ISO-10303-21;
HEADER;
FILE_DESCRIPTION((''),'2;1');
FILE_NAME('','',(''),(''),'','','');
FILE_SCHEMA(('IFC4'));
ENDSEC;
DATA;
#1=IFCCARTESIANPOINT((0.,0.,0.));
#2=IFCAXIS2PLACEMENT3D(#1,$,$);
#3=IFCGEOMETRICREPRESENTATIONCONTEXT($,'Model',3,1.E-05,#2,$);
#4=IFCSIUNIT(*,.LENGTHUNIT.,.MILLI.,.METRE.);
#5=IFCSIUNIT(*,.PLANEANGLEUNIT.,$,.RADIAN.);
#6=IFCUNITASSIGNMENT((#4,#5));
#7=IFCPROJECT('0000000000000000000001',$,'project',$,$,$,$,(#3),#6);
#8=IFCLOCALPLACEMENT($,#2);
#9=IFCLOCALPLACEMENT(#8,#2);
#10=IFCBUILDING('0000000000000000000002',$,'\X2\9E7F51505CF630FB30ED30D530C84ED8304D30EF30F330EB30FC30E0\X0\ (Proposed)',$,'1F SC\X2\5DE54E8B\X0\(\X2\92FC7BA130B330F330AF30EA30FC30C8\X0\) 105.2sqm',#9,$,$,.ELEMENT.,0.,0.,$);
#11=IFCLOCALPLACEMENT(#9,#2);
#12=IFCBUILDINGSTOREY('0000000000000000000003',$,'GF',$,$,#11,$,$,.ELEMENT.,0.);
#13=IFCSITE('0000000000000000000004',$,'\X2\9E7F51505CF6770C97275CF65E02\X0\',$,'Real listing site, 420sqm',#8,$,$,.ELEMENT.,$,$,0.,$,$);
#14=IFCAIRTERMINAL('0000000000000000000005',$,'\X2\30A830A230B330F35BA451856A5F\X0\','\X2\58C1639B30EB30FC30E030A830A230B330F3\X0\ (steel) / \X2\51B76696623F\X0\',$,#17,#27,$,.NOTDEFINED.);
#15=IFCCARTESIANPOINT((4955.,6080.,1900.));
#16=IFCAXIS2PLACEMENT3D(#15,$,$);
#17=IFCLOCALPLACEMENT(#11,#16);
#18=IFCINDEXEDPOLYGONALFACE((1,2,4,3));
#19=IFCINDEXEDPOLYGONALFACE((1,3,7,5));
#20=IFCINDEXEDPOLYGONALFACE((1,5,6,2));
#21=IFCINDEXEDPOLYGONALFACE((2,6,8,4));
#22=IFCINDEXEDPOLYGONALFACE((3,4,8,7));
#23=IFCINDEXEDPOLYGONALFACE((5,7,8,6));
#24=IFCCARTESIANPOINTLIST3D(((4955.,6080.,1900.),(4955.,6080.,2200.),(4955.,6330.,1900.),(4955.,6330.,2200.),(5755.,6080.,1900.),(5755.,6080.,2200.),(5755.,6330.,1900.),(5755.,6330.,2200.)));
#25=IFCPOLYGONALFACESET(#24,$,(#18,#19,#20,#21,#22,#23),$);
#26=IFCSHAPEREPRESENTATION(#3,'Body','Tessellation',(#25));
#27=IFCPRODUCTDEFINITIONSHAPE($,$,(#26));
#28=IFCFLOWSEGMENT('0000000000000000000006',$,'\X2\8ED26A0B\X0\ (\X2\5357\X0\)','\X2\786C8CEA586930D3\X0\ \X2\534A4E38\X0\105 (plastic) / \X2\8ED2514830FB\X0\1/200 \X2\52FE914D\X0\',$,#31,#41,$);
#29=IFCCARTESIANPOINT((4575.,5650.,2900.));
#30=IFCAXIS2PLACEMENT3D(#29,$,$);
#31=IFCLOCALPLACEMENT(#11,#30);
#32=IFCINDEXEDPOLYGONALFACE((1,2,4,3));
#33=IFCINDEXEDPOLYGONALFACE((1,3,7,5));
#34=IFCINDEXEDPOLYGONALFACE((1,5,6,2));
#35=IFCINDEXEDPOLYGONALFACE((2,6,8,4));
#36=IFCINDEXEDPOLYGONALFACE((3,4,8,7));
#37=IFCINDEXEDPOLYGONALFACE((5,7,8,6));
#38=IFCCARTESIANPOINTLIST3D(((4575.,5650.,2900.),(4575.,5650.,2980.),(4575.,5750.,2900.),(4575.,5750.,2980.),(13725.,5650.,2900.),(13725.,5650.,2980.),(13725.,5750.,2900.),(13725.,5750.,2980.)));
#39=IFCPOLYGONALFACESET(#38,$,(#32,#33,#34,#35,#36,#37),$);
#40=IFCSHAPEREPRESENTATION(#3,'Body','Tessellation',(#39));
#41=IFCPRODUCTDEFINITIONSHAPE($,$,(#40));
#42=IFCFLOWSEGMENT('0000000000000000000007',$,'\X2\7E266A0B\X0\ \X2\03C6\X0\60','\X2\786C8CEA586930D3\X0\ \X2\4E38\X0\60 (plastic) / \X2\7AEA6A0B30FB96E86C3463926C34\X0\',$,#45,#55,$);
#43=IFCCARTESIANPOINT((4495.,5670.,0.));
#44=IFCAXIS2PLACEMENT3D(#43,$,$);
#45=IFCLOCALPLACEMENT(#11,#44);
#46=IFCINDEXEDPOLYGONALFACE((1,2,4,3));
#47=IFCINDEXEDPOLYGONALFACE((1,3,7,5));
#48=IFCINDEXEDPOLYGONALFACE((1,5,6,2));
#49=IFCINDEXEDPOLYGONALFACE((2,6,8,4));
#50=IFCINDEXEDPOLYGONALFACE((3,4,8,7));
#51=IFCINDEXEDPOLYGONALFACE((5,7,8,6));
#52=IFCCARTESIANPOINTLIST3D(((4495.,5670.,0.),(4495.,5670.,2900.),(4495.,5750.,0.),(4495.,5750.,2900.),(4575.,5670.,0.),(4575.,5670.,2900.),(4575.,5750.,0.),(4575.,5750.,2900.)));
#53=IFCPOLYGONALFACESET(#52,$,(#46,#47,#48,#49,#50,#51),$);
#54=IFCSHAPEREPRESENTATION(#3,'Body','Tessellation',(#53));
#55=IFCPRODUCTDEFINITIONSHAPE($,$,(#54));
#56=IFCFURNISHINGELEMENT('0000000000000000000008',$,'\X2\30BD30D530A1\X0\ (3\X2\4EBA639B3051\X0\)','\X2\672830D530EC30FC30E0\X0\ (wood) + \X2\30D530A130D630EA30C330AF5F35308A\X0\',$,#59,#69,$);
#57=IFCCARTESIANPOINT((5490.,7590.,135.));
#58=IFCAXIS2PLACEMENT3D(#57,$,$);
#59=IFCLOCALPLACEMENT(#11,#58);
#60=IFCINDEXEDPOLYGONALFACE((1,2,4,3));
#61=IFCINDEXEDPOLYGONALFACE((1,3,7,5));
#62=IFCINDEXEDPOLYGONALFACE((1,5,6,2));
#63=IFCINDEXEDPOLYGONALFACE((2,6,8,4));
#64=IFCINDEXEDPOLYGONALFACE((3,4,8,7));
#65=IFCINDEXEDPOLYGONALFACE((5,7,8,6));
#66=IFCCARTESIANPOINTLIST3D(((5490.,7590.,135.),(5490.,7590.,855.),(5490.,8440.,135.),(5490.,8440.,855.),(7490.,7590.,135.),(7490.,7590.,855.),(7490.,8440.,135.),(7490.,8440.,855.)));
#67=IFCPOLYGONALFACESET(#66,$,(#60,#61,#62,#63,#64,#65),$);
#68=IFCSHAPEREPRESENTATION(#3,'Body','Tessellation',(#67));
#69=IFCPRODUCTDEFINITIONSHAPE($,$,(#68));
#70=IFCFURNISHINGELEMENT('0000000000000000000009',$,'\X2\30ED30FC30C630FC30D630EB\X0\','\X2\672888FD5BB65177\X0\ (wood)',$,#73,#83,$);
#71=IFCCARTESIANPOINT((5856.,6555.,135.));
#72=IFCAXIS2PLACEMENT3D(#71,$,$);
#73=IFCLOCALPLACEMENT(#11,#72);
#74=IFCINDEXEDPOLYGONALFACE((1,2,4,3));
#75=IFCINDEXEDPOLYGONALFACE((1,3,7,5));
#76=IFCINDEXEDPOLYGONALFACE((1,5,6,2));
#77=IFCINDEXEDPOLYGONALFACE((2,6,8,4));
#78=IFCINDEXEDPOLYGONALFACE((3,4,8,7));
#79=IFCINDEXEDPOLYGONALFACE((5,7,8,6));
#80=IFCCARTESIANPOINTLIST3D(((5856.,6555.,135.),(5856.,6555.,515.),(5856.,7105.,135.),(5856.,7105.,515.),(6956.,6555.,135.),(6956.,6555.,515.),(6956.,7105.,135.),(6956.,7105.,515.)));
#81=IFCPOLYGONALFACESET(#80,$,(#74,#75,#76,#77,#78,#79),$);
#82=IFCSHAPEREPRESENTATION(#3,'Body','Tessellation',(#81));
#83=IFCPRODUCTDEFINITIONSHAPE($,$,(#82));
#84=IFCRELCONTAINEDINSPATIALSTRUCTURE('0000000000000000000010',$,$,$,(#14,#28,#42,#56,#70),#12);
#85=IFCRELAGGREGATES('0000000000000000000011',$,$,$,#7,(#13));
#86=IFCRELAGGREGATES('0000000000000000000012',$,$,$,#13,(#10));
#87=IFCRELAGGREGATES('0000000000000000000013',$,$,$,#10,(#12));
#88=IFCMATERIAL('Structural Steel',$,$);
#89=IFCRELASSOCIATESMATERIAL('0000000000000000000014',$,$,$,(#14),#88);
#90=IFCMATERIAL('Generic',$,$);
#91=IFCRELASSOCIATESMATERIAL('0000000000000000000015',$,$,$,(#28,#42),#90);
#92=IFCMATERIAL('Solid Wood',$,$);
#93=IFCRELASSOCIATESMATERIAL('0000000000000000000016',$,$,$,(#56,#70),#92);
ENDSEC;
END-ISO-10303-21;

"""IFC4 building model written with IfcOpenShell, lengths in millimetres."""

from ifc_helpers import new_model, si_unit, frame, frame_2d, origin, place, context, project, spatial, rectangle, extrude, material, element, save


model = new_model("IFC4")

# Units and contexts
model_context = context("Model", 3, precision=1e-05, world=origin())
ifc_project = project(units=[si_unit("LENGTHUNIT", "METRE", prefix="MILLI"), si_unit("PLANEANGLEUNIT", "RADIAN")], contexts=[model_context])

# Site, building, storey
site_placement = place(None, origin())
site = spatial("IfcSite", under=ifc_project, at=site_placement, Name="鹿児島県霧島市", ObjectType="Real listing site, 420sqm", CompositionType="ELEMENT", RefElevation=0.0)
building_placement = place(site_placement, origin())
building = spatial("IfcBuilding", under=site, at=building_placement, Name="鹿児島・ロフト付きワンルーム (Proposed)", ObjectType="1F SC工事(鋼管コンクリート) 105.2sqm", CompositionType="ELEMENT", ElevationOfRefHeight=0.0, ElevationOfTerrain=0.0)
storey_placement = place(building_placement, origin())
storey = spatial("IfcBuildingStorey", under=building, at=storey_placement, Name="GF", CompositionType="ELEMENT", Elevation=0.0)

# Shared definitions
ifc_material_1 = material(Name="Solid Wood")

# Shared definitions
ifc_material_2 = material(Name="Structural Steel")

# Shared definitions
ifc_material_3 = material(Name="Generic")

# Air terminal
air_terminal_placement = place(storey_placement, frame((4955.0, 6080.0, 1900.0)))
element("IfcAirTerminal", 1, at=air_terminal_placement, inside=storey, material=ifc_material_2, Name="エアコン室内機", Description="壁掛ルームエアコン (steel) / 冷暖房", PredefinedType="NOTDEFINED", context=model_context, shape_type="SweptSolid", body=[
    extrude(rectangle(XDim=800.0, YDim=250.0, at=frame_2d((400.0, 125.0))), frame((4955.0, 6080.0, 1900.0)), (0.0, 0.0, 1.0), 300.0),
])

# Flow segments
flow_segment_1_placement = place(storey_placement, frame((4575.0, 5650.0, 2900.0)))
element("IfcFlowSegment", 2, at=flow_segment_1_placement, inside=storey, material=ifc_material_3, Name="軒樋 (南)", Description="硬質塩ビ 半丸105 (plastic) / 軒先・1/200 勾配", context=model_context, shape_type="SweptSolid", body=[
    extrude(rectangle(XDim=9150.0, YDim=100.0, at=frame_2d((4575.0, 50.0))), frame((4575.0, 5650.0, 2900.0)), (0.0, 0.0, 1.0), 80.0),
])
flow_segment_2_placement = place(storey_placement, frame((4495.0, 5670.0, 0.0)))
element("IfcFlowSegment", 3, at=flow_segment_2_placement, inside=storey, material=ifc_material_3, Name="縦樋 φ60", Description="硬質塩ビ 丸60 (plastic) / 竪樋・雨水排水", context=model_context, shape_type="SweptSolid", body=[
    extrude(rectangle(XDim=80.0, YDim=80.0, at=frame_2d((40.0, 40.0))), frame((4495.0, 5670.0, 0.0)), (0.0, 0.0, 1.0), 2900.0),
])

# Furnishing elements
furnishing_1_placement = place(storey_placement, frame((5490.0, 7590.0, 135.0)))
element("IfcFurnishingElement", 4, at=furnishing_1_placement, inside=storey, material=ifc_material_1, Name="ソファ (3人掛け)", Description="木フレーム (wood) + ファブリック張り", context=model_context, shape_type="SweptSolid", body=[
    extrude(rectangle(XDim=2000.0, YDim=850.0, at=frame_2d((1000.0, 425.0))), frame((5490.0, 7590.0, 135.0)), (0.0, 0.0, 1.0), 720.0),
])
furnishing_2_placement = place(storey_placement, frame((5856.0, 6555.0, 135.0)))
element("IfcFurnishingElement", 5, at=furnishing_2_placement, inside=storey, material=ifc_material_1, Name="ローテーブル", Description="木製家具 (wood)", context=model_context, shape_type="SweptSolid", body=[
    extrude(rectangle(XDim=1100.0, YDim=550.0, at=frame_2d((550.0, 275.0))), frame((5856.0, 6555.0, 135.0)), (0.0, 0.0, 1.0), 380.0),
])

save(model, "model.ifc")
